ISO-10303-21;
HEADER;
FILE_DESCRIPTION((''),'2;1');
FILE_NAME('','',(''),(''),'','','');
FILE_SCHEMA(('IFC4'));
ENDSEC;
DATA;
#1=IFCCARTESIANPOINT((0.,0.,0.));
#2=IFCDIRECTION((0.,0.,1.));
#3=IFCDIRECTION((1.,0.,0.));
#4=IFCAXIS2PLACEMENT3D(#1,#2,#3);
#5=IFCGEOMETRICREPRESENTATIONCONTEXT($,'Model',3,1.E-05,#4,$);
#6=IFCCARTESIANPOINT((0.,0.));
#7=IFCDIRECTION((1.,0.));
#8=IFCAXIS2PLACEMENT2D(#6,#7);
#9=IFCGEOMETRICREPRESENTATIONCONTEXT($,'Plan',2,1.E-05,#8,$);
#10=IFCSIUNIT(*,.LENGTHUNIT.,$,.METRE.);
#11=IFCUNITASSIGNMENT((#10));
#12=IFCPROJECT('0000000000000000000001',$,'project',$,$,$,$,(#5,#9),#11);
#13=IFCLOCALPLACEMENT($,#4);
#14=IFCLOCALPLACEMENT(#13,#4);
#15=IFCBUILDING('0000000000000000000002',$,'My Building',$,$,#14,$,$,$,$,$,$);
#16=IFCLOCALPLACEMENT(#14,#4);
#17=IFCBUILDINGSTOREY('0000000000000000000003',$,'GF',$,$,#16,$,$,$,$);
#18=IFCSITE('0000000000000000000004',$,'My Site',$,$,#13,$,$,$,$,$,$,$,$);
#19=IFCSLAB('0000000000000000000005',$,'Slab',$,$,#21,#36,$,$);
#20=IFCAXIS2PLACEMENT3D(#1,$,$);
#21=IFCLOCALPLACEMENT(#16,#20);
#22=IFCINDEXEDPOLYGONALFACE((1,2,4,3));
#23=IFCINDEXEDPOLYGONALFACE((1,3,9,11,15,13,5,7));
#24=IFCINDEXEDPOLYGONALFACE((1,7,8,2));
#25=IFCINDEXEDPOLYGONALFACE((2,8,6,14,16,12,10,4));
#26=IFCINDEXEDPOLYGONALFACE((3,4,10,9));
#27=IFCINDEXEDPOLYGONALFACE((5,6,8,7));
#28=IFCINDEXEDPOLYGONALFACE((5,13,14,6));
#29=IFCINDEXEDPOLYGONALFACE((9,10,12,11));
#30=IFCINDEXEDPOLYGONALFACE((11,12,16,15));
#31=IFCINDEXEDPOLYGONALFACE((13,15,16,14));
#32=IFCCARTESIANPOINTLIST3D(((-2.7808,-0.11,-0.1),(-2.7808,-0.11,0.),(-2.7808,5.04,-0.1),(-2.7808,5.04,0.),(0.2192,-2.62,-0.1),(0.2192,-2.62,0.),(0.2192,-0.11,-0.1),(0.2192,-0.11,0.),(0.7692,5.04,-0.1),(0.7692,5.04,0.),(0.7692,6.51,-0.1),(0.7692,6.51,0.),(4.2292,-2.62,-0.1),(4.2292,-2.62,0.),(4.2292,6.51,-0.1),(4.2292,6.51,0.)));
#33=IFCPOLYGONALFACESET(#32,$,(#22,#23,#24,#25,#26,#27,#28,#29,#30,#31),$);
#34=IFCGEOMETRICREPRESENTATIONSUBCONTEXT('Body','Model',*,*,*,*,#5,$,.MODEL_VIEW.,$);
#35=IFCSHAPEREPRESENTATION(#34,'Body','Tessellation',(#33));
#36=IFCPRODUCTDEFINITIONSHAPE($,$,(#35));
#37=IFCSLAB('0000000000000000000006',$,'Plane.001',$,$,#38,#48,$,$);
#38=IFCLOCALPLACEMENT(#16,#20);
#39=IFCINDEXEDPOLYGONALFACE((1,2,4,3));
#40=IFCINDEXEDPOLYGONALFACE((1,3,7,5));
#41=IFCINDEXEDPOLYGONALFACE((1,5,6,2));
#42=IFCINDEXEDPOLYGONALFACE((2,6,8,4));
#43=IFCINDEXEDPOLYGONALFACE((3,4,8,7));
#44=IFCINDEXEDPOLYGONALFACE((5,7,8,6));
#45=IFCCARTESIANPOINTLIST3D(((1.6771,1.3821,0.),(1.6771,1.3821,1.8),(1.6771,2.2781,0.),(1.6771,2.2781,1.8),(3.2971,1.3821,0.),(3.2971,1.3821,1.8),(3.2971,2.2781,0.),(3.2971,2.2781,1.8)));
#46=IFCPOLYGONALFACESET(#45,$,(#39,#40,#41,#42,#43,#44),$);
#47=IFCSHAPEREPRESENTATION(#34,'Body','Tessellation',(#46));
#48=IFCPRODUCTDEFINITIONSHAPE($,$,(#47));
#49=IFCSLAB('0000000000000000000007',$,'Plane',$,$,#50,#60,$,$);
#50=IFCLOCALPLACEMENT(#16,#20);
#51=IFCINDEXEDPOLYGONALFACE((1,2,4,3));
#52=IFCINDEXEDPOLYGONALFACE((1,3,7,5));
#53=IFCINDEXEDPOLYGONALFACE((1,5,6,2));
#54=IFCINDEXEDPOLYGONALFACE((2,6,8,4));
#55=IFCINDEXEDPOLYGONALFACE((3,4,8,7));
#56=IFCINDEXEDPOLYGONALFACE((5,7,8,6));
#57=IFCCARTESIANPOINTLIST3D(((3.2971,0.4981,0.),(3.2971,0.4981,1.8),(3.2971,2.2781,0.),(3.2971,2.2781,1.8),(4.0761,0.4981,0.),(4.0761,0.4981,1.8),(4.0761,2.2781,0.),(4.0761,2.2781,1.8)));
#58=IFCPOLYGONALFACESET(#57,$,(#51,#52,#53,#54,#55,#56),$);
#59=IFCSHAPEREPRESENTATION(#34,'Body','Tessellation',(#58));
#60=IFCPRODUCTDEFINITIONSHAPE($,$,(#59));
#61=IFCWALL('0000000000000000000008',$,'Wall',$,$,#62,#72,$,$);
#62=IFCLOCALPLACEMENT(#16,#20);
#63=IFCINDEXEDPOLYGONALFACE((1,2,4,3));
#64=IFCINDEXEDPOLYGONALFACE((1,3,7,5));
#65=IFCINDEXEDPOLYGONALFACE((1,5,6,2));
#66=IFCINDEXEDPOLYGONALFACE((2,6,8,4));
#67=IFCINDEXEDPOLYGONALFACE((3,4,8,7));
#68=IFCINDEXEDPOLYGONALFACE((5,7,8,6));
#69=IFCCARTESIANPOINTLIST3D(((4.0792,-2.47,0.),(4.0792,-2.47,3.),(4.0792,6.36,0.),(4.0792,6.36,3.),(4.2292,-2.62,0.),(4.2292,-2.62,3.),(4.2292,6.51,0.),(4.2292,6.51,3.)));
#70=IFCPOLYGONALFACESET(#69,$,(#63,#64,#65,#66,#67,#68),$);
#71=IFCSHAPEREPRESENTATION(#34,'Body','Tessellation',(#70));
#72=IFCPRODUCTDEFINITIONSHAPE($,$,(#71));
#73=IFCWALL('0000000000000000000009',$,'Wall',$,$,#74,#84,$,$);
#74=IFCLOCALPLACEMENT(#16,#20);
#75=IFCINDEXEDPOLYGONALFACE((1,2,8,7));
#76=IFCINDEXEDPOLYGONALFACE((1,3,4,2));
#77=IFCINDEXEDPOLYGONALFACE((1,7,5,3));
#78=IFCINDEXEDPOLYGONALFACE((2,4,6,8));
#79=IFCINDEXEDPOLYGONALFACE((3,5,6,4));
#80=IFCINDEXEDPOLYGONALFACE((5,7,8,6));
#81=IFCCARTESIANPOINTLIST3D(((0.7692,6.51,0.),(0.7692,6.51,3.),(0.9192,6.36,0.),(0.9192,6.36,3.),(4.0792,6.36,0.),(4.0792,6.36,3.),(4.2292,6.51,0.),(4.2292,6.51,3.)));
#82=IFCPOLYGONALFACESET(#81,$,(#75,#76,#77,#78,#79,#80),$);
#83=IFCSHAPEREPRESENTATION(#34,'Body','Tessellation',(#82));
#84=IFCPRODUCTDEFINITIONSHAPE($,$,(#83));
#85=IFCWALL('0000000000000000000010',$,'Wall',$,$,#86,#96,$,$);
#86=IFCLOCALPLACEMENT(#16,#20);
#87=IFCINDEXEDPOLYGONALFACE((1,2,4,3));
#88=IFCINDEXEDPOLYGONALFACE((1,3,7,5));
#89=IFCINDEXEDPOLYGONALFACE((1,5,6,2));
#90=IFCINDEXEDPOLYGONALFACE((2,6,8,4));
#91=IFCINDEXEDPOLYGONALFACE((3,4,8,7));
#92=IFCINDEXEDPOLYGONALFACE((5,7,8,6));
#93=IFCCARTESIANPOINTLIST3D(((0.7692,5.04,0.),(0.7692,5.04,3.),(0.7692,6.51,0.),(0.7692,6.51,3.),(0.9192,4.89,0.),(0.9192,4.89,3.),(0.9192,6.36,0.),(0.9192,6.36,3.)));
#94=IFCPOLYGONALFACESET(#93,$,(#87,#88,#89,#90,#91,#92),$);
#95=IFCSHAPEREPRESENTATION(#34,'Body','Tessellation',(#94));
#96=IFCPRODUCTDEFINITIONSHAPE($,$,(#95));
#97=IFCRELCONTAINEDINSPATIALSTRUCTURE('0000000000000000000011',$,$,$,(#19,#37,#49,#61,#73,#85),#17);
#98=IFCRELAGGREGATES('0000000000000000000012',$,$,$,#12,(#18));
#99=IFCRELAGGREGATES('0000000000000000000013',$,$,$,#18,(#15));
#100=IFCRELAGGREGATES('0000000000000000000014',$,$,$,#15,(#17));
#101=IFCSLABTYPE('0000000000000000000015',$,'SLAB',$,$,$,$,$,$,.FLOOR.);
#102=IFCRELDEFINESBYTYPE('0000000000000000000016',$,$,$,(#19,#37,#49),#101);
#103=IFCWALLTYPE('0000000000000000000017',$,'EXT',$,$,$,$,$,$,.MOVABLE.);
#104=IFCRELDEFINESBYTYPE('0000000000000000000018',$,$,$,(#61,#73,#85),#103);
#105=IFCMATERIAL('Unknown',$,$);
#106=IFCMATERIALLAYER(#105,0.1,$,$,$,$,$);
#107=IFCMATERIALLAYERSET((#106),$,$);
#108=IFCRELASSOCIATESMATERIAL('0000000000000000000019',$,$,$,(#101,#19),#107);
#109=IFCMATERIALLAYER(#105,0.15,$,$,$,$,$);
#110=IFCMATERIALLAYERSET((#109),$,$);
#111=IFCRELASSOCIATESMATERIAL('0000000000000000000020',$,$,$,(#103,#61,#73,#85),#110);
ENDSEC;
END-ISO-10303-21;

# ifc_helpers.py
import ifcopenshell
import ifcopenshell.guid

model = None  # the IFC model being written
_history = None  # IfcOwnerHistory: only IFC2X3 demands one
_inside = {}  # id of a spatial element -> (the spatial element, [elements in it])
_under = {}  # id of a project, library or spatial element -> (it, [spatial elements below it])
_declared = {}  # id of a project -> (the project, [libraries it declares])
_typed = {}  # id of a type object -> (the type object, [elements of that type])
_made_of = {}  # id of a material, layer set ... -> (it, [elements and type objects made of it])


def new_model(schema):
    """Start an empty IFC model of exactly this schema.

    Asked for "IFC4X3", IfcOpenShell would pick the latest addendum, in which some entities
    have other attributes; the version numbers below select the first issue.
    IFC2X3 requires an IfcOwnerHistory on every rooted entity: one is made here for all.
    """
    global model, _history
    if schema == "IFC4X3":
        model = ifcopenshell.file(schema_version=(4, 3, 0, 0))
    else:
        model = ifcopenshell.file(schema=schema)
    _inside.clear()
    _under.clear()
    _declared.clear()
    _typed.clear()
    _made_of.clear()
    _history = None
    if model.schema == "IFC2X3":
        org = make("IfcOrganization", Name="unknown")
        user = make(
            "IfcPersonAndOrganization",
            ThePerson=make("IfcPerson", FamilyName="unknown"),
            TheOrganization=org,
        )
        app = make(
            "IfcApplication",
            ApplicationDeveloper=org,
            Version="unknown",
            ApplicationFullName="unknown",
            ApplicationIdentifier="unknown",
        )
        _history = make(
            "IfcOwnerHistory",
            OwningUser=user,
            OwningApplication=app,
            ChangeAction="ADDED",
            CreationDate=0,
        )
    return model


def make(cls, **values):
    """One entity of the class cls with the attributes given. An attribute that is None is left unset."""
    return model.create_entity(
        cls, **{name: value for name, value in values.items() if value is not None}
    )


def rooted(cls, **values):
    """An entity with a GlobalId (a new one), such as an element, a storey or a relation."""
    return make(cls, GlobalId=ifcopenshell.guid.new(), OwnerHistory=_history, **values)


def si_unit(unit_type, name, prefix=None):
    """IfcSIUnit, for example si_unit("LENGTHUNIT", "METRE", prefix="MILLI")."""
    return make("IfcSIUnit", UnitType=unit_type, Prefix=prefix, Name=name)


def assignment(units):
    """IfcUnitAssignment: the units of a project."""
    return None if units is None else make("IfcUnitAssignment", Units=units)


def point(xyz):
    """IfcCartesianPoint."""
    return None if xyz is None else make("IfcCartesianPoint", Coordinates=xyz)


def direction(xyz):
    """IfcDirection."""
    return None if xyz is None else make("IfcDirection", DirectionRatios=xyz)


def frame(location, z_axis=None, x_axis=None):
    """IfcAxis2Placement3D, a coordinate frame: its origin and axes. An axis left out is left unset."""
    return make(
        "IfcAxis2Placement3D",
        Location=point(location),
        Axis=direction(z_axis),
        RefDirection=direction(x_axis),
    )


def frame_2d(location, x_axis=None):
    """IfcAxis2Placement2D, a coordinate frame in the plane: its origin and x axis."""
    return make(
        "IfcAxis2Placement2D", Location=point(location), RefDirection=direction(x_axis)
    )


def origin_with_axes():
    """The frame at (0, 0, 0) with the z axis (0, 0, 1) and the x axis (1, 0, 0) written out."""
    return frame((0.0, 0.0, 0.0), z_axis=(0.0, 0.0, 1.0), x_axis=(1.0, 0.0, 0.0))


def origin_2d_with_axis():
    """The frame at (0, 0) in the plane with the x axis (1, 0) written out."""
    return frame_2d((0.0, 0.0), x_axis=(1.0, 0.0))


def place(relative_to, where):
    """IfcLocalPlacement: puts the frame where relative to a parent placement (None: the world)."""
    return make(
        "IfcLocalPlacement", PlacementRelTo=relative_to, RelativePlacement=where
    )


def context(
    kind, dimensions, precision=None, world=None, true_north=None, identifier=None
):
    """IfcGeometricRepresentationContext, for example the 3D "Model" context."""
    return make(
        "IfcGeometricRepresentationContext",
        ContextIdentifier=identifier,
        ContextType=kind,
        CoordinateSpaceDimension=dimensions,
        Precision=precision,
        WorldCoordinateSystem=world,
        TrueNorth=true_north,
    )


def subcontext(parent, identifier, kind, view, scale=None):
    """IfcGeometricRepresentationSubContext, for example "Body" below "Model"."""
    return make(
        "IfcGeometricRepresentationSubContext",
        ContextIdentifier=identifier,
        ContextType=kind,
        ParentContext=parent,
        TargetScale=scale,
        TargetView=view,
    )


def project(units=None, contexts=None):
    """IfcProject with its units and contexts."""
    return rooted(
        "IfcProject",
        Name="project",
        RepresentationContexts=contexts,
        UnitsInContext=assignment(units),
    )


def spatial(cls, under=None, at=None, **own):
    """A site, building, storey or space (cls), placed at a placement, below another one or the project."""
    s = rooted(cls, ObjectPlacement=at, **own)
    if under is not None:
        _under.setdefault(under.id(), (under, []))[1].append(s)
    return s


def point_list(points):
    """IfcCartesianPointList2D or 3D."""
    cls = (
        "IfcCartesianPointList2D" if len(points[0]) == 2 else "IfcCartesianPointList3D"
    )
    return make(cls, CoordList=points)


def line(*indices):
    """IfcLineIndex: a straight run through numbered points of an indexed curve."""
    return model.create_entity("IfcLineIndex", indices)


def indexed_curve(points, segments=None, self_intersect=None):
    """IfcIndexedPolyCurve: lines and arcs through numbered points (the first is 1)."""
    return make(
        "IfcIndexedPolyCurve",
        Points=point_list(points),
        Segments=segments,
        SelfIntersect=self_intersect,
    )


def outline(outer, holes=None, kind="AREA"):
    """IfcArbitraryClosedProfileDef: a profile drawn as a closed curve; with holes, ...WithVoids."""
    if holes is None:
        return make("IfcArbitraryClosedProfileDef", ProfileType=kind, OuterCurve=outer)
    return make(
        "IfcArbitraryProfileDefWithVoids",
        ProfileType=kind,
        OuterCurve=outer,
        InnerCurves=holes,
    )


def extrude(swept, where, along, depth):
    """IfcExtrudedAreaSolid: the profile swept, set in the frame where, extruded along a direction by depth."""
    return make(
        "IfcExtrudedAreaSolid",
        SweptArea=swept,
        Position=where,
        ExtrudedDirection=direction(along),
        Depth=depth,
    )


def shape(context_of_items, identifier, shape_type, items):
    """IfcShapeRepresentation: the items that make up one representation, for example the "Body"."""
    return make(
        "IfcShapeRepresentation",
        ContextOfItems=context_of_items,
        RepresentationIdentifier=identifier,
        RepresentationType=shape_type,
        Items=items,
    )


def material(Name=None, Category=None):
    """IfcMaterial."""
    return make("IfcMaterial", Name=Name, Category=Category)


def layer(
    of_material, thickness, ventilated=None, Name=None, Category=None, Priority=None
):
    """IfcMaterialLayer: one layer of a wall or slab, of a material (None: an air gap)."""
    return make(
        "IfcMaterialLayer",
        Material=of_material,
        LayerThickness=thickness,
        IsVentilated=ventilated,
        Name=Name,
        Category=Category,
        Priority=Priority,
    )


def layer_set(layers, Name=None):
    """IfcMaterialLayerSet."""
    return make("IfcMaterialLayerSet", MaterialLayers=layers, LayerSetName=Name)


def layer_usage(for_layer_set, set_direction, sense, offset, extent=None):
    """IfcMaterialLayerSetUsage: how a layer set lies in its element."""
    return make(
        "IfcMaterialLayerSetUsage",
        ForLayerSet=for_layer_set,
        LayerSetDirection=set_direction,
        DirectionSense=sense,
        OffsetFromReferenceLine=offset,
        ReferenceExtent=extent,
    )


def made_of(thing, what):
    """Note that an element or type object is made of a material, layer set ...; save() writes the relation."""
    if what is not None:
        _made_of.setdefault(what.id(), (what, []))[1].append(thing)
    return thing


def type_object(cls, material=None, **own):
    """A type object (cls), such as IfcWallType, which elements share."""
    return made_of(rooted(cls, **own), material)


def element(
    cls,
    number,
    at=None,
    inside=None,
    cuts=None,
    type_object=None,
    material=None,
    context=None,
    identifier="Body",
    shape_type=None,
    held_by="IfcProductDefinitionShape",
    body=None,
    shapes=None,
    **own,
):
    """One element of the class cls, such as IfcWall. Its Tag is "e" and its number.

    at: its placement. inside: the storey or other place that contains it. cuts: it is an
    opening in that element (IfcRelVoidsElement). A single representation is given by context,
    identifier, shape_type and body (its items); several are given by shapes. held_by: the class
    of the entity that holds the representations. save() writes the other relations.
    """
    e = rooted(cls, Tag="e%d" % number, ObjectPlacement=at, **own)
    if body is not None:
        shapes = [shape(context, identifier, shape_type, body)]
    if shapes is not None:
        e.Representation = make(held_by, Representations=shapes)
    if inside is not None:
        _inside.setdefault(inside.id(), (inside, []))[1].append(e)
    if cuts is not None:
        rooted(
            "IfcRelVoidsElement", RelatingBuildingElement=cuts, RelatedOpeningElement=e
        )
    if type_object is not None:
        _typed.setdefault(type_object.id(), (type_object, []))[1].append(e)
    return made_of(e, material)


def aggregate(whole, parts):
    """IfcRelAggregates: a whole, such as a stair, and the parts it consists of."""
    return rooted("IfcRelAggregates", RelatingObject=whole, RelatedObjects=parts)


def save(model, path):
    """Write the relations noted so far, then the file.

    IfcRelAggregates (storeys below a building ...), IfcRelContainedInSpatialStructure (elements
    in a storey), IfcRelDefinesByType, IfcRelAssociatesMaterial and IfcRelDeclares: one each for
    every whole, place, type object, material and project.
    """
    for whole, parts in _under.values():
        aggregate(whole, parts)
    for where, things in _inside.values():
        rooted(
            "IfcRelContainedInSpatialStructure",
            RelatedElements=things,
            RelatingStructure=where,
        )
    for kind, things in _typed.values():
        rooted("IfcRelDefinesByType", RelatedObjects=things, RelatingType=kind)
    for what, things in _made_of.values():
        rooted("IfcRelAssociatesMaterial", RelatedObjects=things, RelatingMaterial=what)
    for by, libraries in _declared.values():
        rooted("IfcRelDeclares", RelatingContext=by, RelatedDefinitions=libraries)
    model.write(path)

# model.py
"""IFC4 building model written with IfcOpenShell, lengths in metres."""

from ifc_helpers import new_model, si_unit, frame, origin_with_axes, origin_2d_with_axis, place, context, subcontext, project, spatial, line, indexed_curve, outline, extrude, material, layer, layer_set, layer_usage, type_object, element, save


model = new_model("IFC4")

# Units and contexts
model_context = context("Model", 3, precision=1e-05, world=origin_with_axes())
plan_context = context("Plan", 2, precision=1e-05, world=origin_2d_with_axis())
body_context_1 = subcontext(model_context, "Body", "Model", "MODEL_VIEW")
ifc_project = project(units=[si_unit("LENGTHUNIT", "METRE")], contexts=[model_context, plan_context])

# Site, building, storey
site_placement = place(None, origin_with_axes())
site = spatial("IfcSite", under=ifc_project, at=site_placement, Name="My Site")
building_placement = place(site_placement, origin_with_axes())
building = spatial("IfcBuilding", under=site, at=building_placement, Name="My Building")
storey_placement = place(building_placement, origin_with_axes())
storey = spatial("IfcBuildingStorey", under=building, at=storey_placement, Name="GF")

# Slabs
ifc_material = material(Name="Unknown")
ifc_layer_1 = layer(ifc_material, 0.1)
ifc_layer_set_1 = layer_set([ifc_layer_1])
ifc_layer_usage_1 = layer_usage(ifc_layer_set_1, "AXIS3", "POSITIVE", -0.1)
slab_type = type_object("IfcSlabType", Name="SLAB", PredefinedType="FLOOR", material=ifc_layer_set_1)
slab_1_placement = place(storey_placement, frame((0.7692, 6.51, 0.0), z_axis=(0.0, 0.0, 1.0), x_axis=(1.0, 0.0, 0.0)))
element("IfcSlab", 1, at=slab_1_placement, inside=storey, type_object=slab_type, material=ifc_layer_usage_1, Name="Slab", context=body_context_1, shape_type="SweptSolid", body=[
    extrude(outline(indexed_curve([(0.0, 0.0), (3.46, 0.0), (3.46, -9.13), (-0.55, -9.13), (-0.55, -6.62), (-3.55, -6.62), (-3.55, -1.47), (0.0, -1.47), (0.0, 0.0)])), frame((0.0, 0.0, -0.1), z_axis=(0.0, 0.0, 1.0), x_axis=(1.0, 0.0, 0.0)), (0.0, 0.0, 1.0), 0.1),
])
slab_2_placement = place(storey_placement, frame((2.4871, 1.8301, 0.0), z_axis=(0.0, 0.0, 1.0), x_axis=(1.0, 0.0, 0.0)))
element("IfcSlab", 2, at=slab_2_placement, inside=storey, type_object=slab_type, Name="Plane.001", context=body_context_1, shape_type="SweptSolid", body=[
    extrude(outline(indexed_curve([(-0.81, -0.448), (0.81, -0.448), (0.81, 0.448), (-0.81, 0.448), (-0.81, -0.448)])), origin_with_axes(), (0.0, 0.0, 1.0), 1.8),
])
slab_3_placement = place(storey_placement, frame((3.6866, 1.3881, 0.0), z_axis=(0.0, 0.0, 1.0), x_axis=(1.0, 0.0, 0.0)))
element("IfcSlab", 3, at=slab_3_placement, inside=storey, type_object=slab_type, Name="Plane", context=body_context_1, shape_type="SweptSolid", body=[
    extrude(outline(indexed_curve([(-0.3895, -0.89), (0.3895, -0.89), (0.3895, 0.89), (-0.3895, 0.89), (-0.3895, -0.89)])), origin_with_axes(), (0.0, 0.0, 1.0), 1.8),
])

# Shared definitions
ifc_layer_2 = layer(ifc_material, 0.15)
ifc_layer_set_2 = layer_set([ifc_layer_2])
wall_type_1 = type_object("IfcWallType", Name="EXT", PredefinedType="MOVABLE", material=ifc_layer_set_2)

# Walls
ifc_layer_usage_2 = layer_usage(ifc_layer_set_2, "AXIS2", "POSITIVE", 0.0)
wall_1_placement = place(storey_placement, frame((4.2292, -2.62, 0.0), z_axis=(0.0, 0.0, 1.0), x_axis=(0.0, 1.0, 0.0)))
element("IfcWall", 4, at=wall_1_placement, inside=storey, type_object=wall_type_1, material=ifc_layer_usage_2, Name="Wall", context=body_context_1, shape_type="SweptSolid", body=[
    extrude(outline(indexed_curve([(0.0, 0.0), (0.15, 0.15), (8.98, 0.15), (9.13, 0.0)], segments=[line(1, 2, 3, 4, 1)])), origin_with_axes(), (0.0, 0.0, 1.0), 3.0),
])
ifc_layer_usage_3 = layer_usage(ifc_layer_set_2, "AXIS2", "POSITIVE", 0.0)
wall_2_placement = place(storey_placement, frame((4.2292, 6.51, 0.0), z_axis=(0.0, 0.0, 1.0), x_axis=(-1.0, 0.0, 0.0)))
element("IfcWall", 5, at=wall_2_placement, inside=storey, type_object=wall_type_1, material=ifc_layer_usage_3, Name="Wall", context=body_context_1, shape_type="SweptSolid", body=[
    extrude(outline(indexed_curve([(0.0, 0.0), (0.15, 0.15), (3.31, 0.15), (3.46, 0.0)], segments=[line(1, 2, 3, 4, 1)])), origin_with_axes(), (0.0, 0.0, 1.0), 3.0),
])
ifc_layer_usage_4 = layer_usage(ifc_layer_set_2, "AXIS2", "POSITIVE", 0.0)
wall_3_placement = place(storey_placement, frame((0.7692, 6.51, 0.0), z_axis=(0.0, 0.0, 1.0), x_axis=(0.0, -1.0, 0.0)))
element("IfcWall", 6, at=wall_3_placement, inside=storey, type_object=wall_type_1, material=ifc_layer_usage_4, Name="Wall", context=body_context_1, shape_type="SweptSolid", body=[
    extrude(outline(indexed_curve([(0.0, 0.0), (0.15, 0.15), (1.62, 0.15), (1.47, 0.0)], segments=[line(1, 2, 3, 4, 1)])), origin_with_axes(), (0.0, 0.0, 1.0), 3.0),
])

save(model, "model.ifc")
